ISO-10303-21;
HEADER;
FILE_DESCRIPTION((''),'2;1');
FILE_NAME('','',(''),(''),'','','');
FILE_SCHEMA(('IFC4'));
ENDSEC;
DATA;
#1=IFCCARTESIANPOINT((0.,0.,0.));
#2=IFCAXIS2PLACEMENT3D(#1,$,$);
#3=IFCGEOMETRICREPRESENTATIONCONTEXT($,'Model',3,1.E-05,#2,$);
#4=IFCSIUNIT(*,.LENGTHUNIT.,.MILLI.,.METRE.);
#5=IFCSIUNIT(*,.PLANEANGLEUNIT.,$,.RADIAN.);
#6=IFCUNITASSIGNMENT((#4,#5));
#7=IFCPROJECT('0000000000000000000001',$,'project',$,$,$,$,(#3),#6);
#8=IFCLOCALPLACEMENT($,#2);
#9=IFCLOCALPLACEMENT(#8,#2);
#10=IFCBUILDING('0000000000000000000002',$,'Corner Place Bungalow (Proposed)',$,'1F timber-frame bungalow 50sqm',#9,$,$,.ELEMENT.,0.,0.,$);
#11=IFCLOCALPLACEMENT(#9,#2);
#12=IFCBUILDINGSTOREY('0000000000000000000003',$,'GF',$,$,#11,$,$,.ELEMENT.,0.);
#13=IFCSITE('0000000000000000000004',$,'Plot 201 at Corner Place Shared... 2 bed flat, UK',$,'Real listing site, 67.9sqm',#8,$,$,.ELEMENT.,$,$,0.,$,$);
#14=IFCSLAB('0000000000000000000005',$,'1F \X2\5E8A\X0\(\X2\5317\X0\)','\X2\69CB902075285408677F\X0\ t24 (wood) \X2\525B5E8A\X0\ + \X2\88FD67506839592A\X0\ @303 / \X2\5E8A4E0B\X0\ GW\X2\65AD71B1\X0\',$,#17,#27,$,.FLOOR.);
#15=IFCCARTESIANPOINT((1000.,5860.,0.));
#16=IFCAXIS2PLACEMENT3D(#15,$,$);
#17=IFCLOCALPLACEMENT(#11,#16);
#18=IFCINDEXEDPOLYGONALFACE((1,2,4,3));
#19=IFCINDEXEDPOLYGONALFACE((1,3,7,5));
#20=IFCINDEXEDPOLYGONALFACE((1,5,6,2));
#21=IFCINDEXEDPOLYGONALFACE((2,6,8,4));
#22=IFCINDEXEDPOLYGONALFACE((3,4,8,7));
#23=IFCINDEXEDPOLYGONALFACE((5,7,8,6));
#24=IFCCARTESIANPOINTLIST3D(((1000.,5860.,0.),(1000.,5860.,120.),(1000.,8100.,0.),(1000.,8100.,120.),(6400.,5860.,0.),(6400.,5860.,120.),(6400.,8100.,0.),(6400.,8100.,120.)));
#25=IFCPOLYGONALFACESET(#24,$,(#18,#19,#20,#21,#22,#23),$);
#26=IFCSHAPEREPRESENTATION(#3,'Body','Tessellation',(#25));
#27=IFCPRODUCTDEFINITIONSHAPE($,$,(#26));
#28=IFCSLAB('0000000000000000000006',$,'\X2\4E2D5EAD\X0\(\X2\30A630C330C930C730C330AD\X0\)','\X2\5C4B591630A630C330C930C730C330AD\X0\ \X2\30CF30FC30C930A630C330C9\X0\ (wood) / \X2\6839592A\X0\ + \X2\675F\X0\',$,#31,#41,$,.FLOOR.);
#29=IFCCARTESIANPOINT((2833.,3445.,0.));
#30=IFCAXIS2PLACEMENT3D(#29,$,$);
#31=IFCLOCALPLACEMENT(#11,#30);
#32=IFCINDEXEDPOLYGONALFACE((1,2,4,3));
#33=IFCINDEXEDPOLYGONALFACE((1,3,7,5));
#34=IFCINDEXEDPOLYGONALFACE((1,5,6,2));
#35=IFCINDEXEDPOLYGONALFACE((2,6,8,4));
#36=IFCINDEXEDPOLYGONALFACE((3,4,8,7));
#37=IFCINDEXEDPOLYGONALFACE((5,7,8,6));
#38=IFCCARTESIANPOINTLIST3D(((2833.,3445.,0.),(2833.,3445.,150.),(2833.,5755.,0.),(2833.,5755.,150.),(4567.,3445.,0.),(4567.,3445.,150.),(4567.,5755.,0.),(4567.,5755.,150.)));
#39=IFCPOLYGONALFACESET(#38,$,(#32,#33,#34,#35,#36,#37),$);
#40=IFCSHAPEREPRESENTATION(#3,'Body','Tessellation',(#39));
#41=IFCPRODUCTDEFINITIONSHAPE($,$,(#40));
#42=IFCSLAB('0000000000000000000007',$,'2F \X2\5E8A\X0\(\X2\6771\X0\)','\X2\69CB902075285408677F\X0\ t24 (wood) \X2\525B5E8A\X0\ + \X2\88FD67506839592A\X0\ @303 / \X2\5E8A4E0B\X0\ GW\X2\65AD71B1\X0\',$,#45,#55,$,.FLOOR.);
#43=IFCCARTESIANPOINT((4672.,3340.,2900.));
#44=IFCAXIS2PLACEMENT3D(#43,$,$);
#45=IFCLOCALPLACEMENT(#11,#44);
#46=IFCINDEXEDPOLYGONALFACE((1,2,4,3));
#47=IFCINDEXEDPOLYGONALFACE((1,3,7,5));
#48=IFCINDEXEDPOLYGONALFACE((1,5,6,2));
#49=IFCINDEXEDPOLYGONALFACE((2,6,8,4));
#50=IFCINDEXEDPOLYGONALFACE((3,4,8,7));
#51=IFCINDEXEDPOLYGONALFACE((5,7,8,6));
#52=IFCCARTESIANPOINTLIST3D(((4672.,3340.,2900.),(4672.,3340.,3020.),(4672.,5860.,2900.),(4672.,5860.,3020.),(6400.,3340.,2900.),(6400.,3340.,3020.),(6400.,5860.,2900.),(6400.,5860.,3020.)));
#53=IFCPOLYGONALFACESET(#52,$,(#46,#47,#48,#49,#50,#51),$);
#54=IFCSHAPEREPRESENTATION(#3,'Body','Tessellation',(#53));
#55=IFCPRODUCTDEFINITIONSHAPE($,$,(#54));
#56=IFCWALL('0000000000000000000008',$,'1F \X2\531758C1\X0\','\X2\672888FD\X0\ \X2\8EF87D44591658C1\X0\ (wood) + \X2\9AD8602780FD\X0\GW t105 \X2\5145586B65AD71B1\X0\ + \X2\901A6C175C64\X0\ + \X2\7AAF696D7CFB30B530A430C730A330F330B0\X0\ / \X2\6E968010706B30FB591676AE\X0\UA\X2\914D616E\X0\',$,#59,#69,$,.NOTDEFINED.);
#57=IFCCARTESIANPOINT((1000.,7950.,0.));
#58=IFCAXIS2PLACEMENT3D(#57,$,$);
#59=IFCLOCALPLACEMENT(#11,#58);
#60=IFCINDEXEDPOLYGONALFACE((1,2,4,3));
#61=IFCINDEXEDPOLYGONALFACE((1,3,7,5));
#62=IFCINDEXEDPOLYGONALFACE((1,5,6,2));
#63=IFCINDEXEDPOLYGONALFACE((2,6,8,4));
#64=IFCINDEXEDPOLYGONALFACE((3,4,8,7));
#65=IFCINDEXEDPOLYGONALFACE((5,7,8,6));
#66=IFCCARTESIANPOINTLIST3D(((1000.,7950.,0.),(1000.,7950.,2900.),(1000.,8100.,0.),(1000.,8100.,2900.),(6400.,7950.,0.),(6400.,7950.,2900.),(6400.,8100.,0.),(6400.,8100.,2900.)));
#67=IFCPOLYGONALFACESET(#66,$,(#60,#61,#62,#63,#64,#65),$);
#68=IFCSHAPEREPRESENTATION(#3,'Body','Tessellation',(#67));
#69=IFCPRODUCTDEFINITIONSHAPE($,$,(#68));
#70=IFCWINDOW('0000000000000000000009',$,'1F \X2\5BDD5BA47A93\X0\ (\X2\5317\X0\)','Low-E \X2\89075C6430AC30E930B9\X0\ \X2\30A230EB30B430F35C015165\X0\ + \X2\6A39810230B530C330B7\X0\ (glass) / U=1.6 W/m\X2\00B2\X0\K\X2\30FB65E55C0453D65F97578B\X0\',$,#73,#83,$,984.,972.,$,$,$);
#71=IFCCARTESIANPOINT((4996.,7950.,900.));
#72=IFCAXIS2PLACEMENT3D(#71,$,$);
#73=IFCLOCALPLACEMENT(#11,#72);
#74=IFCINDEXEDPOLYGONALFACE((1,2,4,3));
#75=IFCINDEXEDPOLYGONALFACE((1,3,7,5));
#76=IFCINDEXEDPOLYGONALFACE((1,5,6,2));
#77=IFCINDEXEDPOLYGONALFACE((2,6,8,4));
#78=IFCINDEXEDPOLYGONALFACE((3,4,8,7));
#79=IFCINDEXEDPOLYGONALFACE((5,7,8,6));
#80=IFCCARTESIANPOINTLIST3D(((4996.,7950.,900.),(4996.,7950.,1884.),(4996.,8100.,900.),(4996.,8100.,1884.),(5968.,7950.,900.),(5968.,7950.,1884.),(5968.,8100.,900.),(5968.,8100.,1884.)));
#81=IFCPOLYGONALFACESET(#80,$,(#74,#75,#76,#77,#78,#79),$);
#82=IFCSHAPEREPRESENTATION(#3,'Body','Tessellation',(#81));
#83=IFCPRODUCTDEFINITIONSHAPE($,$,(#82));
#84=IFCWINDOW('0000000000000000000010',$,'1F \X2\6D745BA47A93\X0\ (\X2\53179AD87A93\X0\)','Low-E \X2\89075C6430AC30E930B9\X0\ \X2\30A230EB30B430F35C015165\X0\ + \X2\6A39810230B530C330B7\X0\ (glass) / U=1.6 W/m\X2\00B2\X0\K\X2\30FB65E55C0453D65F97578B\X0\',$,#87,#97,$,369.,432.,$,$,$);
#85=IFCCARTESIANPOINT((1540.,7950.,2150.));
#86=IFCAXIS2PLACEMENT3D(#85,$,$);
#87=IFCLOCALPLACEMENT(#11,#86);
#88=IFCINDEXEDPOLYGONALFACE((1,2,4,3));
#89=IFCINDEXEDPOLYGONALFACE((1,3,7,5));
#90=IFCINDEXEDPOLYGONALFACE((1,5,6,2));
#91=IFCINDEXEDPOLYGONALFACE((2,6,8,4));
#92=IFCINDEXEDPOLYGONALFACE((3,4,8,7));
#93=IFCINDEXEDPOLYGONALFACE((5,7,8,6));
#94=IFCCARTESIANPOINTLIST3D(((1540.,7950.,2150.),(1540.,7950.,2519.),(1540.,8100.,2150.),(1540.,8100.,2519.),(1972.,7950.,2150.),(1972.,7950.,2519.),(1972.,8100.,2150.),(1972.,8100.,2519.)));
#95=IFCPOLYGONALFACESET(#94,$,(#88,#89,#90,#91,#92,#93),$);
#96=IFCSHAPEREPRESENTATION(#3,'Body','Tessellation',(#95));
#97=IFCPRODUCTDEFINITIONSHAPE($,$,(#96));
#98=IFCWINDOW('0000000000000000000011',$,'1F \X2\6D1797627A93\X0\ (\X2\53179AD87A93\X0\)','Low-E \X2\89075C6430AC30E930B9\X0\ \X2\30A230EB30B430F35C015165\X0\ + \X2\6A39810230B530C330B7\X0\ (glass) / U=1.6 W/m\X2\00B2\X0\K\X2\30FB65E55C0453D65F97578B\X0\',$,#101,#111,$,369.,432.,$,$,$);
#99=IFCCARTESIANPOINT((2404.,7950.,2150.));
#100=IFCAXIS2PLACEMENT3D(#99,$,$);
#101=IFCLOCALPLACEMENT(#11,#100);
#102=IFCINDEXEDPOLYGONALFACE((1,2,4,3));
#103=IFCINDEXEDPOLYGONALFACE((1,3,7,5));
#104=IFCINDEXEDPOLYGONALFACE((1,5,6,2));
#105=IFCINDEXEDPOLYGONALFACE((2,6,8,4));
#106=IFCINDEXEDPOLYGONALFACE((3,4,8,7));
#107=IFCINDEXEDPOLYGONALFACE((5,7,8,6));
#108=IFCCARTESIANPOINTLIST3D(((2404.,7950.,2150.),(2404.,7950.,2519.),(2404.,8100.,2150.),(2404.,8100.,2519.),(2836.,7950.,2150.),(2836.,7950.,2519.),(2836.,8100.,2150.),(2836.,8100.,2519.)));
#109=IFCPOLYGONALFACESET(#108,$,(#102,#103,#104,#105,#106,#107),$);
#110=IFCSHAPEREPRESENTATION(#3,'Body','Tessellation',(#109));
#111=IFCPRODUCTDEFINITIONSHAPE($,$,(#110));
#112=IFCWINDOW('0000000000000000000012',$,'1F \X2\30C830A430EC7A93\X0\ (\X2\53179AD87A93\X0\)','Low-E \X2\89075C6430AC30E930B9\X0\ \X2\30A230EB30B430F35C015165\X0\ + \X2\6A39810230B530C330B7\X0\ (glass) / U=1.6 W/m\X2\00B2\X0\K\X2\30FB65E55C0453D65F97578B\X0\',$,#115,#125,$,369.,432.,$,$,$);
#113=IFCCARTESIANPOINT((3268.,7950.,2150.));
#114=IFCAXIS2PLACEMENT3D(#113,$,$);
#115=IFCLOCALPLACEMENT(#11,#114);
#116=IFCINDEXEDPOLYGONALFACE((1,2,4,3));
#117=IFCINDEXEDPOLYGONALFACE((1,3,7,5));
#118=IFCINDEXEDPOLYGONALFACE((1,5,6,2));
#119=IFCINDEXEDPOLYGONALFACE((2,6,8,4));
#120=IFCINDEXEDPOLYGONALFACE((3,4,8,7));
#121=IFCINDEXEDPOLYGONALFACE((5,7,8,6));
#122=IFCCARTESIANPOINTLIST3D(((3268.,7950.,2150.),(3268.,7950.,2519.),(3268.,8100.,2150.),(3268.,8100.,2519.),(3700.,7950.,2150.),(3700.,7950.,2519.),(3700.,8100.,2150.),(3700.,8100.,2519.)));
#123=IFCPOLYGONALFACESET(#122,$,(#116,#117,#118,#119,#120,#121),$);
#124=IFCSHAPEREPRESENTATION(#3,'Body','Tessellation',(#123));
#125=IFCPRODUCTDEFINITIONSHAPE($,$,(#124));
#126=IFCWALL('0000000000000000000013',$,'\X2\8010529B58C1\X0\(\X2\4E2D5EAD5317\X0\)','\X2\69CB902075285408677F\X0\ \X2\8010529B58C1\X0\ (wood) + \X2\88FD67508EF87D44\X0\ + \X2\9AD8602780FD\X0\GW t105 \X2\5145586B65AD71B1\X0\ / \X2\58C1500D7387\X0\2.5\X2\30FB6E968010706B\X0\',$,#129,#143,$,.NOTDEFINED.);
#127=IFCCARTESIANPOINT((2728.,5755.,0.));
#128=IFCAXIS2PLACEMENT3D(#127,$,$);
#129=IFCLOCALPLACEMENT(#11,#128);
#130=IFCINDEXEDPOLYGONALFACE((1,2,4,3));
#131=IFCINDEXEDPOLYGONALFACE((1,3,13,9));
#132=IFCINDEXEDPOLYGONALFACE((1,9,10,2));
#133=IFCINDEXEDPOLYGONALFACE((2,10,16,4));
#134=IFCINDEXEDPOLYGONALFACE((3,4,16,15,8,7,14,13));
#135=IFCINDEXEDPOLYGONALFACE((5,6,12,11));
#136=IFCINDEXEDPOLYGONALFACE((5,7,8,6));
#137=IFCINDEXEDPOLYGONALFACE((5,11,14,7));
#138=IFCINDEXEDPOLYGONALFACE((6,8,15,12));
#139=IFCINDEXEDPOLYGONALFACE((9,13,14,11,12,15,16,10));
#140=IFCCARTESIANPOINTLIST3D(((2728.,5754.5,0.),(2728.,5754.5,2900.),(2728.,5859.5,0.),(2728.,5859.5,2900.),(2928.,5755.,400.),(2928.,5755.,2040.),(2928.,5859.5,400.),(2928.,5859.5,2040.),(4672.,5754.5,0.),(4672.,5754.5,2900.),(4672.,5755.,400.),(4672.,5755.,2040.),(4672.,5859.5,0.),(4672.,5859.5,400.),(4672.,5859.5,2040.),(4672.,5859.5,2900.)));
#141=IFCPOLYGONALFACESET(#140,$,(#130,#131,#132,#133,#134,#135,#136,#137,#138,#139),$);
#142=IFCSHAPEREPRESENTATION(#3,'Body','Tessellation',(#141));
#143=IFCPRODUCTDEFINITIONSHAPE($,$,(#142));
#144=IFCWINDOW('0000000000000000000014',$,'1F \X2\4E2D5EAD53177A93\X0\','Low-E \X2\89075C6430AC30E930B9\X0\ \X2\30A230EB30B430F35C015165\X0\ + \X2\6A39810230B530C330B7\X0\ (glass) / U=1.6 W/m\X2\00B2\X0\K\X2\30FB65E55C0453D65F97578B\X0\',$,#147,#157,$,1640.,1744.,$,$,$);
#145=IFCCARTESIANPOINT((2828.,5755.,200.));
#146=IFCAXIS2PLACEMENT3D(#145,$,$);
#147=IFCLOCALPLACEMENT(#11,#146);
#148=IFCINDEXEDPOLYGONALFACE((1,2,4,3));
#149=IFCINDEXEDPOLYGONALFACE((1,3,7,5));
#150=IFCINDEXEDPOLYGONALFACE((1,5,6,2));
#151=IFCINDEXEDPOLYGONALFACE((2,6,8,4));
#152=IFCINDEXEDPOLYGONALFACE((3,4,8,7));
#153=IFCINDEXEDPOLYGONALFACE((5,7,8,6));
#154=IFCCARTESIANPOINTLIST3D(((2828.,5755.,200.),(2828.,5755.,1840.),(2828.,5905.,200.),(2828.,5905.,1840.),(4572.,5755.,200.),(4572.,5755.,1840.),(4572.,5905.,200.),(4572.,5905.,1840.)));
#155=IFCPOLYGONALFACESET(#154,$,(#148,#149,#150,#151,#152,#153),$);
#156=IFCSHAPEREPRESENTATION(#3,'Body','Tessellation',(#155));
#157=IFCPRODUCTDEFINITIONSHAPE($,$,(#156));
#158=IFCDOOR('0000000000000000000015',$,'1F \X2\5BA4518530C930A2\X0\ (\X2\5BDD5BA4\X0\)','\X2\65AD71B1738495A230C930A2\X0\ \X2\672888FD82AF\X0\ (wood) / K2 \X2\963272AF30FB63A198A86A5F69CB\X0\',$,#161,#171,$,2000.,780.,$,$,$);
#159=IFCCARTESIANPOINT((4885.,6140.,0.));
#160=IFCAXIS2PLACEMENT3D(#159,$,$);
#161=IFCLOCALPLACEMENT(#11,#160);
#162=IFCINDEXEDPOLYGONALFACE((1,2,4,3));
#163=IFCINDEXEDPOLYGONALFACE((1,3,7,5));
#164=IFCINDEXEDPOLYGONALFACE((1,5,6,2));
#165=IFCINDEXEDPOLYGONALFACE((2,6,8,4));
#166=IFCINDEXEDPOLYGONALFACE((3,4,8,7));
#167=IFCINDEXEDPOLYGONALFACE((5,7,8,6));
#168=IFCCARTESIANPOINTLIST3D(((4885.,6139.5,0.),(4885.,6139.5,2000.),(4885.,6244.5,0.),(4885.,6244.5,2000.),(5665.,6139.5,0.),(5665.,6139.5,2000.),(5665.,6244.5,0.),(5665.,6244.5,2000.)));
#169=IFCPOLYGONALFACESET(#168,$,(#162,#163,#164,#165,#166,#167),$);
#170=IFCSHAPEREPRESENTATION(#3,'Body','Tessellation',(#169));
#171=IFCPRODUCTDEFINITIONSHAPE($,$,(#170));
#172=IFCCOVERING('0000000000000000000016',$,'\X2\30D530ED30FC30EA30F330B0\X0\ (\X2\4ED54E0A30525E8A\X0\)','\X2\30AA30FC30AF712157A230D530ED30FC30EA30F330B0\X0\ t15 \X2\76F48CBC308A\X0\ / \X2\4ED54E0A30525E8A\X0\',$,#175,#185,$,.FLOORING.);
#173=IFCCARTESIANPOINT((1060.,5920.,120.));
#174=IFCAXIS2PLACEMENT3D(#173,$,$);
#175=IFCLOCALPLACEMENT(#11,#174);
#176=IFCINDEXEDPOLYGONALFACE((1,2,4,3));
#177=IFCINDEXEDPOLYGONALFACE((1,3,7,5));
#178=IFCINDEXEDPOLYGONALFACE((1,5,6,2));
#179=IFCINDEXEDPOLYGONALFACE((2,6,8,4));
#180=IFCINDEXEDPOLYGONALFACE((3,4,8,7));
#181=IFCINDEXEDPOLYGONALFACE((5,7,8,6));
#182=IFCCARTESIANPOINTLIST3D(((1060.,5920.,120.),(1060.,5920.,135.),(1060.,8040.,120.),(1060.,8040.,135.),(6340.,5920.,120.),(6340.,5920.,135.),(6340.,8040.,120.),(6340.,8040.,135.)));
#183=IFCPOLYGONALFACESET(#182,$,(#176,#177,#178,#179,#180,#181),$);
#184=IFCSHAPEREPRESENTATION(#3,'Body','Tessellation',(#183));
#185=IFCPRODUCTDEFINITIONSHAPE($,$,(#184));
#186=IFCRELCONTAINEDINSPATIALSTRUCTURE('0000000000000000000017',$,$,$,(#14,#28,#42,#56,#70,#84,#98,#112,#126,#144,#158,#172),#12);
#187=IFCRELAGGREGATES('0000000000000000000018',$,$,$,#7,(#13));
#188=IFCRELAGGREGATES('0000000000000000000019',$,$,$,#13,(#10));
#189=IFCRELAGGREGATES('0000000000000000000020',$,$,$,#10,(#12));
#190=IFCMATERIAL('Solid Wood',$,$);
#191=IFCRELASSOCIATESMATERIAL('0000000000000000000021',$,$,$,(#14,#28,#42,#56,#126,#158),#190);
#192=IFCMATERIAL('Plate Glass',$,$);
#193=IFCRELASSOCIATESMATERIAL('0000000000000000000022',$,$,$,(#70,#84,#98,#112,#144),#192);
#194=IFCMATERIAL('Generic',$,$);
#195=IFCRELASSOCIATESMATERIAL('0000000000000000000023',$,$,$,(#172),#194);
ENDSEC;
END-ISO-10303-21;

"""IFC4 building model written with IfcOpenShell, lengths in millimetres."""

from ifc_helpers import new_model, si_unit, frame, frame_2d, origin, place, context, project, spatial, rectangle, extrude, material, element, fill, save


model = new_model("IFC4")

# Units and contexts
model_context = context("Model", 3, precision=1e-05, world=origin())
ifc_project = project(units=[si_unit("LENGTHUNIT", "METRE", prefix="MILLI"), si_unit("PLANEANGLEUNIT", "RADIAN")], contexts=[model_context])

# Site, building, storey
site_placement = place(None, origin())
site = spatial("IfcSite", under=ifc_project, at=site_placement, Name="Plot 201 at Corner Place Shared... 2 bed flat, UK", ObjectType="Real listing site, 67.9sqm", CompositionType="ELEMENT", RefElevation=0.0)
building_placement = place(site_placement, origin())
building = spatial("IfcBuilding", under=site, at=building_placement, Name="Corner Place Bungalow (Proposed)", ObjectType="1F timber-frame bungalow 50sqm", CompositionType="ELEMENT", ElevationOfRefHeight=0.0, ElevationOfTerrain=0.0)
storey_placement = place(building_placement, origin())
storey = spatial("IfcBuildingStorey", under=building, at=storey_placement, Name="GF", CompositionType="ELEMENT", Elevation=0.0)

# Slabs
ifc_material_1 = material(Name="Solid Wood")
slab_1_placement = place(storey_placement, frame((1000.0, 5860.0, 0.0)))
element("IfcSlab", 1, at=slab_1_placement, inside=storey, material=ifc_material_1, Name="1F 床(北)", Description="構造用合板 t24 (wood) 剛床 + 製材根太 @303 / 床下 GW断熱", PredefinedType="FLOOR", context=model_context, shape_type="SweptSolid", body=[
    extrude(rectangle(XDim=5400.0, YDim=2240.0, at=frame_2d((2700.0, 1120.0))), frame((1000.0, 5860.0, 0.0)), (0.0, 0.0, 1.0), 120.0),
])
slab_2_placement = place(storey_placement, frame((2833.0, 3445.0, 0.0)))
element("IfcSlab", 2, at=slab_2_placement, inside=storey, material=ifc_material_1, Name="中庭(ウッドデッキ)", Description="屋外ウッドデッキ ハードウッド (wood) / 根太 + 束", PredefinedType="FLOOR", context=model_context, shape_type="SweptSolid", body=[
    extrude(rectangle(XDim=1734.0, YDim=2310.0, at=frame_2d((867.0, 1155.0))), frame((2833.0, 3445.0, 0.0)), (0.0, 0.0, 1.0), 150.0),
])
slab_3_placement = place(storey_placement, frame((4672.0, 3340.0, 2900.0)))
element("IfcSlab", 3, at=slab_3_placement, inside=storey, material=ifc_material_1, Name="2F 床(東)", Description="構造用合板 t24 (wood) 剛床 + 製材根太 @303 / 床下 GW断熱", PredefinedType="FLOOR", context=model_context, shape_type="SweptSolid", body=[
    extrude(rectangle(XDim=1728.0, YDim=2520.0, at=frame_2d((864.0, 1260.0))), frame((4672.0, 3340.0, 2900.0)), (0.0, 0.0, 1.0), 120.0),
])

# Wall, openings, windows
wall_1_placement = place(storey_placement, frame((1000.0, 7950.0, 0.0)))
wall_1 = element("IfcWall", 4, at=wall_1_placement, inside=storey, material=ifc_material_1, Name="1F 北壁", Description="木製 軸組外壁 (wood) + 高性能GW t105 充填断熱 + 通気層 + 窯業系サイディング / 準耐火・外皮UA配慮", PredefinedType="NOTDEFINED", context=model_context, shape_type="SweptSolid", body=[
    extrude(rectangle(XDim=5400.0, YDim=150.0, at=frame_2d((2700.0, 75.0))), frame((1000.0, 7950.0, 0.0)), (0.0, 0.0, 1.0), 2900.0),
])
opening_1_placement = place(storey_placement, frame((4996.0, 7950.0, 900.0)))
opening_1 = element("IfcOpeningElement", 5, at=opening_1_placement, cuts=wall_1, PredefinedType="NOTDEFINED", context=model_context, shape_type="SweptSolid", body=[
    extrude(rectangle(XDim=972.0, YDim=150.0, at=frame_2d((486.0, 75.0))), frame((4996.0, 7950.0, 900.0)), (0.0, 0.0, 1.0), 984.0),
])
opening_2_placement = place(storey_placement, frame((1540.0, 7950.0, 2150.0)))
opening_2 = element("IfcOpeningElement", 6, at=opening_2_placement, cuts=wall_1, PredefinedType="NOTDEFINED", context=model_context, shape_type="SweptSolid", body=[
    extrude(rectangle(XDim=432.0, YDim=150.0, at=frame_2d((216.0, 75.0))), frame((1540.0, 7950.0, 2150.0)), (0.0, 0.0, 1.0), 369.0),
])
opening_3_placement = place(storey_placement, frame((2404.0, 7950.0, 2150.0)))
opening_3 = element("IfcOpeningElement", 7, at=opening_3_placement, cuts=wall_1, PredefinedType="NOTDEFINED", context=model_context, shape_type="SweptSolid", body=[
    extrude(rectangle(XDim=432.0, YDim=150.0, at=frame_2d((216.0, 75.0))), frame((2404.0, 7950.0, 2150.0)), (0.0, 0.0, 1.0), 369.0),
])
opening_4_placement = place(storey_placement, frame((3268.0, 7950.0, 2150.0)))
opening_4 = element("IfcOpeningElement", 8, at=opening_4_placement, cuts=wall_1, PredefinedType="NOTDEFINED", context=model_context, shape_type="SweptSolid", body=[
    extrude(rectangle(XDim=432.0, YDim=150.0, at=frame_2d((216.0, 75.0))), frame((3268.0, 7950.0, 2150.0)), (0.0, 0.0, 1.0), 369.0),
])
ifc_material_2 = material(Name="Plate Glass")
window_1_placement = place(storey_placement, frame((4996.0, 7950.0, 900.0)))
window_1 = element("IfcWindow", 9, at=window_1_placement, inside=storey, material=ifc_material_2, Name="1F 寝室窓 (北)", Description="Low-E 複層ガラス アルゴン封入 + 樹脂サッシ (glass) / U=1.6 W/m²K・日射取得型", OverallHeight=984.0, OverallWidth=972.0, context=model_context, shape_type="SweptSolid", body=[
    extrude(rectangle(XDim=972.0, YDim=150.0, at=frame_2d((486.0, 75.0))), frame((4996.0, 7950.0, 900.0)), (0.0, 0.0, 1.0), 984.0),
])
fill(opening_1, window_1)
window_2_placement = place(storey_placement, frame((1540.0, 7950.0, 2150.0)))
window_2 = element("IfcWindow", 10, at=window_2_placement, inside=storey, material=ifc_material_2, Name="1F 浴室窓 (北高窓)", Description="Low-E 複層ガラス アルゴン封入 + 樹脂サッシ (glass) / U=1.6 W/m²K・日射取得型", OverallHeight=369.0, OverallWidth=432.0, context=model_context, shape_type="SweptSolid", body=[
    extrude(rectangle(XDim=432.0, YDim=150.0, at=frame_2d((216.0, 75.0))), frame((1540.0, 7950.0, 2150.0)), (0.0, 0.0, 1.0), 369.0),
])
fill(opening_2, window_2)
window_3_placement = place(storey_placement, frame((2404.0, 7950.0, 2150.0)))
window_3 = element("IfcWindow", 11, at=window_3_placement, inside=storey, material=ifc_material_2, Name="1F 洗面窓 (北高窓)", Description="Low-E 複層ガラス アルゴン封入 + 樹脂サッシ (glass) / U=1.6 W/m²K・日射取得型", OverallHeight=369.0, OverallWidth=432.0, context=model_context, shape_type="SweptSolid", body=[
    extrude(rectangle(XDim=432.0, YDim=150.0, at=frame_2d((216.0, 75.0))), frame((2404.0, 7950.0, 2150.0)), (0.0, 0.0, 1.0), 369.0),
])
fill(opening_3, window_3)
window_4_placement = place(storey_placement, frame((3268.0, 7950.0, 2150.0)))
window_4 = element("IfcWindow", 12, at=window_4_placement, inside=storey, material=ifc_material_2, Name="1F トイレ窓 (北高窓)", Description="Low-E 複層ガラス アルゴン封入 + 樹脂サッシ (glass) / U=1.6 W/m²K・日射取得型", OverallHeight=369.0, OverallWidth=432.0, context=model_context, shape_type="SweptSolid", body=[
    extrude(rectangle(XDim=432.0, YDim=150.0, at=frame_2d((216.0, 75.0))), frame((3268.0, 7950.0, 2150.0)), (0.0, 0.0, 1.0), 369.0),
])
fill(opening_4, window_4)

# Wall, opening, window
wall_2_placement = place(storey_placement, frame((2728.0, 5755.0, 0.0)))
wall_2 = element("IfcWall", 13, at=wall_2_placement, inside=storey, material=ifc_material_1, Name="耐力壁(中庭北)", Description="構造用合板 耐力壁 (wood) + 製材軸組 + 高性能GW t105 充填断熱 / 壁倍率2.5・準耐火", PredefinedType="NOTDEFINED", context=model_context, shape_type="SweptSolid", body=[
    extrude(rectangle(XDim=1944.0, YDim=105.0, at=frame_2d((972.0, 52.0))), frame((2728.0, 5755.0, 0.0)), (0.0, 0.0, 1.0), 2900.0),
])
opening_5_placement = place(storey_placement, frame((2828.0, 5755.0, 200.0)))
opening_5 = element("IfcOpeningElement", 14, at=opening_5_placement, cuts=wall_2, PredefinedType="NOTDEFINED", context=model_context, shape_type="SweptSolid", body=[
    extrude(rectangle(XDim=1744.0, YDim=150.0, at=frame_2d((872.0, 75.0))), frame((2828.0, 5755.0, 200.0)), (0.0, 0.0, 1.0), 1640.0),
])
window_5_placement = place(storey_placement, frame((2828.0, 5755.0, 200.0)))
window_5 = element("IfcWindow", 15, at=window_5_placement, inside=storey, material=ifc_material_2, Name="1F 中庭北窓", Description="Low-E 複層ガラス アルゴン封入 + 樹脂サッシ (glass) / U=1.6 W/m²K・日射取得型", OverallHeight=1640.0, OverallWidth=1744.0, context=model_context, shape_type="SweptSolid", body=[
    extrude(rectangle(XDim=1744.0, YDim=150.0, at=frame_2d((872.0, 75.0))), frame((2828.0, 5755.0, 200.0)), (0.0, 0.0, 1.0), 1640.0),
])
fill(opening_5, window_5)

# Door
door_1_placement = place(storey_placement, frame((4885.0, 6140.0, 0.0)))
element("IfcDoor", 16, at=door_1_placement, inside=storey, material=ifc_material_1, Name="1F 室内ドア (寝室)", Description="断熱玄関ドア 木製芯 (wood) / K2 防犯・採風機構", OverallHeight=2000.0, OverallWidth=780.0, context=model_context, shape_type="SweptSolid", body=[
    extrude(rectangle(XDim=780.0, YDim=105.0, at=frame_2d((390.0, 52.0))), frame((4885.0, 6140.0, 0.0)), (0.0, 0.0, 1.0), 2000.0),
])

# Covering
ifc_material_3 = material(Name="Generic")
covering_1_placement = place(storey_placement, frame((1060.0, 5920.0, 120.0)))
element("IfcCovering", 17, at=covering_1_placement, inside=storey, material=ifc_material_3, Name="フローリング (仕上げ床)", Description="オーク無垢フローリング t15 直貼り / 仕上げ床", PredefinedType="FLOORING", context=model_context, shape_type="SweptSolid", body=[
    extrude(rectangle(XDim=5280.0, YDim=2120.0, at=frame_2d((2640.0, 1060.0))), frame((1060.0, 5920.0, 120.0)), (0.0, 0.0, 1.0), 15.0),
])

save(model, "model.ifc")
